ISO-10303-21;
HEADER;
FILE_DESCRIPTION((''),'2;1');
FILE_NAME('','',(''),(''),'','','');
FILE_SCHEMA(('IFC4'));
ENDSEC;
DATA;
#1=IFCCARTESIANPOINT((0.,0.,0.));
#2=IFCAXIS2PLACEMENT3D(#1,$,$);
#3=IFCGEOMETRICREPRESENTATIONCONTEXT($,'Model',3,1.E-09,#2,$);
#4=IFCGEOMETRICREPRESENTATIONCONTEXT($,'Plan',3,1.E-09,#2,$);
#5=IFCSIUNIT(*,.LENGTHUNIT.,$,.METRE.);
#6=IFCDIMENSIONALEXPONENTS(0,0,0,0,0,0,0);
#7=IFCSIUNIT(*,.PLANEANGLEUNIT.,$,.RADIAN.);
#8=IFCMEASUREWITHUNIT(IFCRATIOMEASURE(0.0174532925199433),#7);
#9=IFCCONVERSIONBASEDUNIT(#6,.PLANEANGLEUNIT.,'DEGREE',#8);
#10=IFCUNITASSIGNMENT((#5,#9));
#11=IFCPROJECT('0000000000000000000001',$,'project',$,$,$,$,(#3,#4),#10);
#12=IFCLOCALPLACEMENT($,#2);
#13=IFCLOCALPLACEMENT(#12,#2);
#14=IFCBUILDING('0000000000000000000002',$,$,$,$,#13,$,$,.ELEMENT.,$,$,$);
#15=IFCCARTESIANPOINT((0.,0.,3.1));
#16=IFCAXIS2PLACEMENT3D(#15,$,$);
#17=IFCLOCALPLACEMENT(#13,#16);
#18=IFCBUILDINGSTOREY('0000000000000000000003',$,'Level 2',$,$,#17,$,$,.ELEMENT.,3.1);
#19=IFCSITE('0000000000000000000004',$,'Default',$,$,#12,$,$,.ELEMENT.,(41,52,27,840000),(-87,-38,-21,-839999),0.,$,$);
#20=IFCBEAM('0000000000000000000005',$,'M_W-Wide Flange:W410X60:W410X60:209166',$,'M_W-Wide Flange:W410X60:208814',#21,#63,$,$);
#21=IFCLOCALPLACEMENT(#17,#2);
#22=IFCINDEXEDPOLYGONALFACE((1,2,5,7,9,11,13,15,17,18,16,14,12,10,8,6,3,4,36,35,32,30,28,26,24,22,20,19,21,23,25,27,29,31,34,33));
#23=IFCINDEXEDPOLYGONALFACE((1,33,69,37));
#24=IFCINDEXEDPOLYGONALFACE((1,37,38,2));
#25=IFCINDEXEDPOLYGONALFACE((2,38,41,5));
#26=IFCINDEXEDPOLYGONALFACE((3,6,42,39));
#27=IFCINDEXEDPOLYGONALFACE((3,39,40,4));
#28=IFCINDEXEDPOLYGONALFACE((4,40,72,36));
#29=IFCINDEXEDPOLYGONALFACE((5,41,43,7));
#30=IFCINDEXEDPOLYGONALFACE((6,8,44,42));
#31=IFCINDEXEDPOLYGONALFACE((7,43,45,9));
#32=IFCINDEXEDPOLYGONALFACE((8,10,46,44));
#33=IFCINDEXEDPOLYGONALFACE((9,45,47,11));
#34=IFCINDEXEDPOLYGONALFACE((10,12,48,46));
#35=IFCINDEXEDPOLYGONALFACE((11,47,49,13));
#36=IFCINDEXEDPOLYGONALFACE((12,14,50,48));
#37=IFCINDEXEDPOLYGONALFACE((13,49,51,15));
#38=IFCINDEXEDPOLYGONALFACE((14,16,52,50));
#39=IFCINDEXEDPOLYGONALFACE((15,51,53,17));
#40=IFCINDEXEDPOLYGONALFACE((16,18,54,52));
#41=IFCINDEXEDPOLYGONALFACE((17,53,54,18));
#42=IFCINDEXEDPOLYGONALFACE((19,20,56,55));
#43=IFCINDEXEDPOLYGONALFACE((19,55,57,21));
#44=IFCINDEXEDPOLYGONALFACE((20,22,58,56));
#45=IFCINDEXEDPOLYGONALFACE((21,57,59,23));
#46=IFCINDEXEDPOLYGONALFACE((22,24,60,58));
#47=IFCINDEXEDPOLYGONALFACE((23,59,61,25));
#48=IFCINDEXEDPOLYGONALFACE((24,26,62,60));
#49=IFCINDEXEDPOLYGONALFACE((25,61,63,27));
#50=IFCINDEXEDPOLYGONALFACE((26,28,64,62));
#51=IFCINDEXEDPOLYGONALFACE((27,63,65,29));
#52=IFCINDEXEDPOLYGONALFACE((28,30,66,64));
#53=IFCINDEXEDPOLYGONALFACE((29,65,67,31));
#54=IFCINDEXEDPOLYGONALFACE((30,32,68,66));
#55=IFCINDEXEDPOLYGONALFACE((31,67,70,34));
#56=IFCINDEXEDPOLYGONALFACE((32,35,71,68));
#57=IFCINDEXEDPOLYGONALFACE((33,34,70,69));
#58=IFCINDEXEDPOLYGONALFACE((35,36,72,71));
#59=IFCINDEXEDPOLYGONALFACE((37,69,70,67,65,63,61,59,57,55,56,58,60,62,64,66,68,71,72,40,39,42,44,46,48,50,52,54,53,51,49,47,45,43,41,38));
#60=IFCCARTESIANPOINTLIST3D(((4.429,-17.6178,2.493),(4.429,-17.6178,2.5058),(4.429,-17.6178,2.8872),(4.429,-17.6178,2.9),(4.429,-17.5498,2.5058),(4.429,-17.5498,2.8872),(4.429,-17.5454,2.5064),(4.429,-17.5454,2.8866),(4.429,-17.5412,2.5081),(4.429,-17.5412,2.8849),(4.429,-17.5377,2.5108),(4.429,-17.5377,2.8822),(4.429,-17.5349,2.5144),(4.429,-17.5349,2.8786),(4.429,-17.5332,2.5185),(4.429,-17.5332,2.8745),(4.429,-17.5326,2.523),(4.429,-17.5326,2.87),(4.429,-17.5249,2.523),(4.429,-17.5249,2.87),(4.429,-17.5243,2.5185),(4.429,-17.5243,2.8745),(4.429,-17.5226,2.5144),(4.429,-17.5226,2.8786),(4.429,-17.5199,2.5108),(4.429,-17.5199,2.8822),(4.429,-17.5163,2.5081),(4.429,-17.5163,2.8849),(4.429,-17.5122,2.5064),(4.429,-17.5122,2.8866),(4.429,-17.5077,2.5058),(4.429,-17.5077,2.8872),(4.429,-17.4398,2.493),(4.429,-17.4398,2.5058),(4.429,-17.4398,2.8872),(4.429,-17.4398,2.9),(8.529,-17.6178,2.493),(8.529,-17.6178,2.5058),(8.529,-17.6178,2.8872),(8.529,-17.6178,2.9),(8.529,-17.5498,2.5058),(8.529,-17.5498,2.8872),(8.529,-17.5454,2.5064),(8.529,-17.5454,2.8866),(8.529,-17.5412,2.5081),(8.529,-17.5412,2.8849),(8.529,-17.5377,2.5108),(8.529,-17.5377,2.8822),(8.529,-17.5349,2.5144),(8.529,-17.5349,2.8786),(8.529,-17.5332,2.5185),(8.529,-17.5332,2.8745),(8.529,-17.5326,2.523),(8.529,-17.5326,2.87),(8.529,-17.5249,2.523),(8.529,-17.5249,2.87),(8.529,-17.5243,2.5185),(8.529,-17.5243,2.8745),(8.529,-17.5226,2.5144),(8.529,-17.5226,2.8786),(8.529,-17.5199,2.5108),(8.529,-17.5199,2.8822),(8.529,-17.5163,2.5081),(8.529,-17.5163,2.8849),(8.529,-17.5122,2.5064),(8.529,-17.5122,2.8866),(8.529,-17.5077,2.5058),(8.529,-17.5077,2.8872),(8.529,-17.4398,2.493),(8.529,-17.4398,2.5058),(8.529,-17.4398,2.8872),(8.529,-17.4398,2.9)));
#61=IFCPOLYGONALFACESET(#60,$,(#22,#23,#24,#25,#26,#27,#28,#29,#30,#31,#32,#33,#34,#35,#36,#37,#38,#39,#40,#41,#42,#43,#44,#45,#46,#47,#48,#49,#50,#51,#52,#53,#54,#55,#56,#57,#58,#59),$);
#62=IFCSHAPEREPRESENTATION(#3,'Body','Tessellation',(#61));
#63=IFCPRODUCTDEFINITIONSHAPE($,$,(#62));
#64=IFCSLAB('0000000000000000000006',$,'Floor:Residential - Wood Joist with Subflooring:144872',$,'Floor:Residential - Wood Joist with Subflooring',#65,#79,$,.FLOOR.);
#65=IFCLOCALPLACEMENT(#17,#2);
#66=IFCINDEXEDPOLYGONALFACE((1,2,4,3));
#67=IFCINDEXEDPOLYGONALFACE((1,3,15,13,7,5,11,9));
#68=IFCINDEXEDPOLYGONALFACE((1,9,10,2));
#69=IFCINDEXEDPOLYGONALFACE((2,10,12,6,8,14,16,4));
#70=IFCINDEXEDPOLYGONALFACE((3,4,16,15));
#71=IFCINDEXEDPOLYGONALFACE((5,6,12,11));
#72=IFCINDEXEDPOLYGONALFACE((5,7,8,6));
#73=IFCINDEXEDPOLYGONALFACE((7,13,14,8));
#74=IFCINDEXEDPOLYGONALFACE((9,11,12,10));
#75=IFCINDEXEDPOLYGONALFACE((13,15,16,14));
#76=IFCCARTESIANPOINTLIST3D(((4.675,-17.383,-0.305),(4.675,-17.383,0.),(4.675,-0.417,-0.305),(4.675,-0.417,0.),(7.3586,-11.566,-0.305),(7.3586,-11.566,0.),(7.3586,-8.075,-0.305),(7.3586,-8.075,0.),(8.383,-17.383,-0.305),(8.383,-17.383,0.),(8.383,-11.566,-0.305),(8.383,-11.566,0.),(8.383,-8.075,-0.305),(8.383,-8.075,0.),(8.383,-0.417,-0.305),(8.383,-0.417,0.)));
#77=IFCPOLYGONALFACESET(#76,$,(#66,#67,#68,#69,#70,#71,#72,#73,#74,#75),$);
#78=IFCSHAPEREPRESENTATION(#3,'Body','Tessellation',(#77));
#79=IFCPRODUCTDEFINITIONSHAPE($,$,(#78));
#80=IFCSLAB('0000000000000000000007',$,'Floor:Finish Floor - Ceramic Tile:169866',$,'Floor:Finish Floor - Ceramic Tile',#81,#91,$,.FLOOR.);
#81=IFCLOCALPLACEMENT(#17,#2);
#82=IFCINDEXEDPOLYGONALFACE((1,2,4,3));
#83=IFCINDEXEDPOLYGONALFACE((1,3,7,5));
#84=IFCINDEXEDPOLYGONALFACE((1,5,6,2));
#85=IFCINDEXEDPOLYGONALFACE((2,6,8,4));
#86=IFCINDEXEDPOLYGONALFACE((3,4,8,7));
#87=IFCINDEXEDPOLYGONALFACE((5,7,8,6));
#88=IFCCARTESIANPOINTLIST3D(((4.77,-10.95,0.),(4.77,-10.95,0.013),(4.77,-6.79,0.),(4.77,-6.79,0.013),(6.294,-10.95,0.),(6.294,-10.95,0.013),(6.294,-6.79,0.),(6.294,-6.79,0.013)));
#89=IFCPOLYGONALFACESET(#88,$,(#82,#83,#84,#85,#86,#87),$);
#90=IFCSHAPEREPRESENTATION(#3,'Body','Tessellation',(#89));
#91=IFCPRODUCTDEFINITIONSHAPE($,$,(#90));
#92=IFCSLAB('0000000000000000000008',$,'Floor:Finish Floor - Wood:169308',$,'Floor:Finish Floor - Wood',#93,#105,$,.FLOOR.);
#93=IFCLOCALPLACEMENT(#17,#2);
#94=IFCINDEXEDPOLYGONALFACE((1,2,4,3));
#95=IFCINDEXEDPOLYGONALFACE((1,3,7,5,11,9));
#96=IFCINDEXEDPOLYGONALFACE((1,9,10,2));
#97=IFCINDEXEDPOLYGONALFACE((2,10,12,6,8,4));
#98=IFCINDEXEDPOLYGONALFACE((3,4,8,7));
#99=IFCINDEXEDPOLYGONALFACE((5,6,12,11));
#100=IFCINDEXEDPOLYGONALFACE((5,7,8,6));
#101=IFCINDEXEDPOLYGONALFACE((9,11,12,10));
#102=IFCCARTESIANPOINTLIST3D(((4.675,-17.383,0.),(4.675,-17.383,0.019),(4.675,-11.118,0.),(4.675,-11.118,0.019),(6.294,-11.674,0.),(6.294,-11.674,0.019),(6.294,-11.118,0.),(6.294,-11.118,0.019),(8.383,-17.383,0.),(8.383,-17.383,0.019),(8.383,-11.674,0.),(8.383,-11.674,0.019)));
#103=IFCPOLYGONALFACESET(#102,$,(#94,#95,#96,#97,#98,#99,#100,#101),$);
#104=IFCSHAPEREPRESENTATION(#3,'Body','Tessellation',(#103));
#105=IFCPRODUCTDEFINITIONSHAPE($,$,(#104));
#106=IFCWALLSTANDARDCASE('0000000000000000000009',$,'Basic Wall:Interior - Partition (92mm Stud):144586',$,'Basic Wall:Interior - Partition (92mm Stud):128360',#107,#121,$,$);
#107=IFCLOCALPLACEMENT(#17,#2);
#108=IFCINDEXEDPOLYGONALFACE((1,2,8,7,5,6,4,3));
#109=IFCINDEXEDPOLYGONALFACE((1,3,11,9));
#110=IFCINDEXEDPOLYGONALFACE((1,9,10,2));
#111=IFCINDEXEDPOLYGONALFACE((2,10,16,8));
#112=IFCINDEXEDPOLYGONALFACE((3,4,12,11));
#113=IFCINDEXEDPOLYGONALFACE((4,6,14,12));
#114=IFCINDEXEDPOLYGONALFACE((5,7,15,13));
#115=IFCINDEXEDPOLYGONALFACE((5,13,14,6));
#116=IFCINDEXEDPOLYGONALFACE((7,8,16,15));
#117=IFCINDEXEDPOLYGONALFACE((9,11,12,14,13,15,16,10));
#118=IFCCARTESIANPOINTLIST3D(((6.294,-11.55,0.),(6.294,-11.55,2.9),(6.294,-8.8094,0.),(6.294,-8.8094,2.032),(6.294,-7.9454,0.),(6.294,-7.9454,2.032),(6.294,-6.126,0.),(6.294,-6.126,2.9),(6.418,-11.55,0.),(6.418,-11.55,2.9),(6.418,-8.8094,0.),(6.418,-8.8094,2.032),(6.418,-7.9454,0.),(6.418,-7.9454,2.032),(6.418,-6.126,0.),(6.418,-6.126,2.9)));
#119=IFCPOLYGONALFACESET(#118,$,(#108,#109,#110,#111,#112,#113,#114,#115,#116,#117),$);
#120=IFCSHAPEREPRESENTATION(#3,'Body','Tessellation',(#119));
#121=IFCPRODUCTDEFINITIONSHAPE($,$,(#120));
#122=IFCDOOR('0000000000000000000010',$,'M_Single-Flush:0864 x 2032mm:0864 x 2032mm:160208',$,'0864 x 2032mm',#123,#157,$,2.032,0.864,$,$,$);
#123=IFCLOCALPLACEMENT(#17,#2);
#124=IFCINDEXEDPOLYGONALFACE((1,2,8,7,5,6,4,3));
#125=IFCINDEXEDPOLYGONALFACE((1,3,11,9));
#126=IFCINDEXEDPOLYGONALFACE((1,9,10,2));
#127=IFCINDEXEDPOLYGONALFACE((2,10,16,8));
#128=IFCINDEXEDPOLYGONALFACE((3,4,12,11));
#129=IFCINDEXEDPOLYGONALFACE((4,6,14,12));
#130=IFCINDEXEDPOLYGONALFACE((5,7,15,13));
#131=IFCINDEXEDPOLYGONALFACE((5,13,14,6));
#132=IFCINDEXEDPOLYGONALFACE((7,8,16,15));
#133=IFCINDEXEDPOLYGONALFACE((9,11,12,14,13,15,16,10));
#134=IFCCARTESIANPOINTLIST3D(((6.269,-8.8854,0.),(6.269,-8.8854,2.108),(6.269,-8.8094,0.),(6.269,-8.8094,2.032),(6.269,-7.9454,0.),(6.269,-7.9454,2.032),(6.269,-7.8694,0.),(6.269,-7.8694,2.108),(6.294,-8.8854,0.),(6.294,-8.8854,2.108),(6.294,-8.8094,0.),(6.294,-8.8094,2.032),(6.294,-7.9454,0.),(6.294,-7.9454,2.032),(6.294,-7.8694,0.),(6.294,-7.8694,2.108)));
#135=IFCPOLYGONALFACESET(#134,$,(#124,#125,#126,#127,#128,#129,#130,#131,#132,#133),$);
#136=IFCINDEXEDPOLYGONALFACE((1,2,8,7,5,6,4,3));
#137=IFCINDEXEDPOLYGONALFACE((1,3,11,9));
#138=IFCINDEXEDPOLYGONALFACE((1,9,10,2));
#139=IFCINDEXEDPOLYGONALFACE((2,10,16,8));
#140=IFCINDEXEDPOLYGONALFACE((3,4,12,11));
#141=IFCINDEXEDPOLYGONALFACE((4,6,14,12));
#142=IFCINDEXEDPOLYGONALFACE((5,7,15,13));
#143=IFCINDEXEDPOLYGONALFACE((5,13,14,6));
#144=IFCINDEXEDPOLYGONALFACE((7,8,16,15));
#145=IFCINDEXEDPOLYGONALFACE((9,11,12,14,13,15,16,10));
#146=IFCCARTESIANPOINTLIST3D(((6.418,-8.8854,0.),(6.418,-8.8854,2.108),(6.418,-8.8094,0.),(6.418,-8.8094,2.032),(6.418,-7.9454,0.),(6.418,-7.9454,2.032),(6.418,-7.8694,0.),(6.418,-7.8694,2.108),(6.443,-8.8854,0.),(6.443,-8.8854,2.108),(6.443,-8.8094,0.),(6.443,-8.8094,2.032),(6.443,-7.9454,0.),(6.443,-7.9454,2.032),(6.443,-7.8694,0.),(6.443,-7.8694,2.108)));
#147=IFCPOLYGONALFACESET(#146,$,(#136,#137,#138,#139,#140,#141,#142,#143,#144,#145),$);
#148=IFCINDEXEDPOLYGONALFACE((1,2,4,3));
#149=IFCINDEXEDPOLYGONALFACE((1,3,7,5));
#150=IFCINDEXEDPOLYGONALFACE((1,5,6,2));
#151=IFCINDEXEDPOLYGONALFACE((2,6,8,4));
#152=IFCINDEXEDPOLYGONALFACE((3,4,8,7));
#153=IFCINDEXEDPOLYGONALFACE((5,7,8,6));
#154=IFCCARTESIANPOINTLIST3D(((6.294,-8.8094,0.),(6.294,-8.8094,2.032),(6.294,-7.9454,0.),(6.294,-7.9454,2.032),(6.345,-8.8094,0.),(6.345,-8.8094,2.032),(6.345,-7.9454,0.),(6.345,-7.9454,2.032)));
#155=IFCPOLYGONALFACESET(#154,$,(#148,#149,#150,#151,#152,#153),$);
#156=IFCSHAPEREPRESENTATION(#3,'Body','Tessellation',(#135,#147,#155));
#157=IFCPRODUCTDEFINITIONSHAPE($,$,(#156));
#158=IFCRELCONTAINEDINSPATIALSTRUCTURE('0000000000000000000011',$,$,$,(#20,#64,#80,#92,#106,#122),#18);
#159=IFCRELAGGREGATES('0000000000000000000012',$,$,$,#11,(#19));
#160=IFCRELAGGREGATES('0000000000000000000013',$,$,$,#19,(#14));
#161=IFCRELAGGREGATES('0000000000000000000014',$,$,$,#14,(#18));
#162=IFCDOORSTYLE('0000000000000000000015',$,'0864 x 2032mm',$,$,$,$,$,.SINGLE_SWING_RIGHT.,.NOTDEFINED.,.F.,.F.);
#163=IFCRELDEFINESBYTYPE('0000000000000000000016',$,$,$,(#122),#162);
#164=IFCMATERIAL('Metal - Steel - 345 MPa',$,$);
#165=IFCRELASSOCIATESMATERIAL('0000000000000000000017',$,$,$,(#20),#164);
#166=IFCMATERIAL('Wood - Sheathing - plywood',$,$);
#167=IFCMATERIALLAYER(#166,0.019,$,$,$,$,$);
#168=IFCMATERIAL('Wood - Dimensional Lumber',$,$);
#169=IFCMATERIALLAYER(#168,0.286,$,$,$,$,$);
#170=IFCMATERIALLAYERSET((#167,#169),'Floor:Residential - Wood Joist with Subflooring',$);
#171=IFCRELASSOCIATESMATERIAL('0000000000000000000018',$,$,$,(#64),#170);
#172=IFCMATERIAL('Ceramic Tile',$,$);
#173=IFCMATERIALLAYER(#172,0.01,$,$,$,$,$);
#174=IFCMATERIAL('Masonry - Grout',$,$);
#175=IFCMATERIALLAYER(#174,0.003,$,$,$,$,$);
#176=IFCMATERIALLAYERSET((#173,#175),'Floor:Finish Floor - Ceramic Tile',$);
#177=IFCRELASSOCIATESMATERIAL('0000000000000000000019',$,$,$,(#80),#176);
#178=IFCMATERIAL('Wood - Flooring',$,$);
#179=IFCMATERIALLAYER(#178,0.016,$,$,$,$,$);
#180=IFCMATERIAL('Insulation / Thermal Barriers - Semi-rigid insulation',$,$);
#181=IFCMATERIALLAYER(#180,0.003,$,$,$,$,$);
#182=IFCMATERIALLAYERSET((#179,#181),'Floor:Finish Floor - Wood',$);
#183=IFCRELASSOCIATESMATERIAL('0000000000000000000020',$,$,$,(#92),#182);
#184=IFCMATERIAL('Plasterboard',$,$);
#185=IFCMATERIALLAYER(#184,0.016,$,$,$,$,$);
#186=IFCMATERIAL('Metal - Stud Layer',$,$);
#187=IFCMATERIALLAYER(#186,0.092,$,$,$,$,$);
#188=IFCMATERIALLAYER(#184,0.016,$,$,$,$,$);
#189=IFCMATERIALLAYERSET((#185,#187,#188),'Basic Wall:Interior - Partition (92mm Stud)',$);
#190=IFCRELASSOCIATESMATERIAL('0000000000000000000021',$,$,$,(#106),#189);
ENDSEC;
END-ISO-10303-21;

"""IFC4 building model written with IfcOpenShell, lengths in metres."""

from ifc_helpers import new_model, entity, si_unit, converted_unit, frame, frame_2d, origin, origin_2d_with_axis, place, context, project, spatial, polyline, circle_curve, parameter, trimmed, segment, composite_curve, rectangle, outline, extrude, source, transform, mapped, material, layer, layer_set, layer_usage, type_object, type_shapes, element, fill, save


model = new_model("IFC4")

# Units and contexts
model_context = context("Model", 3, precision=1e-09, world=origin())
plan_context = context("Plan", 3, precision=1e-09, world=origin())
ifc_project = project(units=[si_unit("LENGTHUNIT", "METRE"), converted_unit("PLANEANGLEUNIT", "DEGREE", entity("IfcRatioMeasure", 0.0174532925199433), si_unit("PLANEANGLEUNIT", "RADIAN"), dimensions=[0, 0, 0, 0, 0, 0, 0])], contexts=[model_context, plan_context])

# Site, building, storey
site_placement = place(None, origin())
site = spatial("IfcSite", under=ifc_project, at=site_placement, Name="Default", CompositionType="ELEMENT", RefLatitude=(41, 52, 27, 840000), RefLongitude=(-87, -38, -21, -839999), RefElevation=0.0)
building_placement = place(site_placement, origin())
building = spatial("IfcBuilding", under=site, at=building_placement, CompositionType="ELEMENT")
storey_placement = place(building_placement, frame((0.0, 0.0, 3.1)))
storey = spatial("IfcBuildingStorey", under=building, at=storey_placement, Name="Level 2", CompositionType="ELEMENT", Elevation=3.1)

# Beam
ifc_material_1 = material(Name="Metal - Steel - 345 MPa")
beam_placement = place(storey_placement, frame((4.429, -17.5288, 2.9), z_axis=(0.0, 0.0, 1.0), x_axis=(0.0, -1.0, 0.0)))
element("IfcBeam", 1, at=beam_placement, inside=storey, material=ifc_material_1, Name="M_W-Wide Flange:W410X60:W410X60:209166", ObjectType="M_W-Wide Flange:W410X60:208814", context=model_context, shape_type="SweptSolid", body=[
    extrude(outline(composite_curve([segment(polyline([(-0.089, -0.1907), (-0.089, -0.2035)]), True, "CONTINUOUS"), segment(polyline([(-0.089, -0.2035), (0.089, -0.2035)]), True, "CONTINUOUS"), segment(polyline([(0.089, -0.2035), (0.089, -0.1907)]), True, "CONTINUOUS"), segment(polyline([(0.089, -0.1907), (0.021, -0.1907)]), True, "CONTINUOUS"), segment(trimmed(circle_curve(frame_2d((0.021, -0.1735), x_axis=(0.0, -1.0)), 0.0172), [parameter(270.0)], [parameter(360.0)], True, "PARAMETER"), False, "CONTINUOUS"), segment(polyline([(0.0038, -0.1735), (0.0038, 0.1735)]), True, "CONTINUOUS"), segment(trimmed(circle_curve(frame_2d((0.021, 0.1735), x_axis=(-1.0, 0.0)), 0.0172), [parameter(270.0)], [parameter(360.0)], True, "PARAMETER"), False, "CONTINUOUS"), segment(polyline([(0.021, 0.1907), (0.089, 0.1907)]), True, "CONTINUOUS"), segment(polyline([(0.089, 0.1907), (0.089, 0.2035)]), True, "CONTINUOUS"), segment(polyline([(0.089, 0.2035), (-0.089, 0.2035)]), True, "CONTINUOUS"), segment(polyline([(-0.089, 0.2035), (-0.089, 0.1907)]), True, "CONTINUOUS"), segment(polyline([(-0.089, 0.1907), (-0.0211, 0.1907)]), True, "CONTINUOUS"), segment(trimmed(circle_curve(frame_2d((-0.0211, 0.1735), x_axis=(0.0, 1.0)), 0.0172), [parameter(270.0)], [parameter(0.0)], True, "PARAMETER"), False, "CONTINUOUS"), segment(polyline([(-0.0039, 0.1735), (-0.0039, -0.1735)]), True, "CONTINUOUS"), segment(trimmed(circle_curve(frame_2d((-0.0211, -0.1735), x_axis=(1.0, 0.0)), 0.0172), [parameter(270.0)], [parameter(0.0)], True, "PARAMETER"), False, "CONTINUOUS"), segment(polyline([(-0.0211, -0.1907), (-0.089, -0.1907)]), True, "CONTINUOUS")], self_intersect=False)), frame((0.0, 0.0, -0.2035), z_axis=(0.0, -1.0, 0.0), x_axis=(1.0, 0.0, 0.0)), (0.0, 0.0, -1.0), 4.1),
])

# Slabs
ifc_material_2 = material(Name="Wood - Sheathing - plywood")
ifc_layer_1 = layer(ifc_material_2, 0.019)
ifc_material_3 = material(Name="Wood - Dimensional Lumber")
ifc_layer_2 = layer(ifc_material_3, 0.286)
ifc_layer_set_1 = layer_set([ifc_layer_1, ifc_layer_2], Name="Floor:Residential - Wood Joist with Subflooring")
ifc_layer_usage_1 = layer_usage(ifc_layer_set_1, "AXIS3", "POSITIVE", 0.0)
slab_1_placement = place(storey_placement, frame((4.675, -17.383, -0.305)))
element("IfcSlab", 2, at=slab_1_placement, inside=storey, material=ifc_layer_usage_1, Name="Floor:Residential - Wood Joist with Subflooring:144872", ObjectType="Floor:Residential - Wood Joist with Subflooring", PredefinedType="FLOOR", context=model_context, shape_type="SweptSolid", body=[
    extrude(outline(polyline([(-1.854, 8.483), (-1.854, 0.825), (-0.8296, 0.825), (-0.8296, -2.666), (-1.854, -2.666), (-1.854, -8.483), (1.854, -8.483), (1.854, 8.483), (-1.854, 8.483)])), frame((1.854, 8.483, 0.305), z_axis=(0.0, 0.0, -1.0), x_axis=(-1.0, 0.0, 0.0)), (0.0, 0.0, 1.0), 0.305),
])
ifc_material_4 = material(Name="Ceramic Tile")
ifc_layer_3 = layer(ifc_material_4, 0.01)
ifc_material_5 = material(Name="Masonry - Grout")
ifc_layer_4 = layer(ifc_material_5, 0.003)
ifc_layer_set_2 = layer_set([ifc_layer_3, ifc_layer_4], Name="Floor:Finish Floor - Ceramic Tile")
ifc_layer_usage_2 = layer_usage(ifc_layer_set_2, "AXIS3", "POSITIVE", 0.0)
slab_2_placement = place(storey_placement, frame((4.77, -10.95, 0.0)))
element("IfcSlab", 3, at=slab_2_placement, inside=storey, material=ifc_layer_usage_2, Name="Floor:Finish Floor - Ceramic Tile:169866", ObjectType="Floor:Finish Floor - Ceramic Tile", PredefinedType="FLOOR", context=model_context, shape_type="SweptSolid", body=[
    extrude(rectangle(XDim=4.16, YDim=1.524, at=frame_2d((0.0, 0.0), x_axis=(0.0, -1.0))), frame((0.762, 2.08, 0.013), z_axis=(0.0, 0.0, -1.0), x_axis=(-1.0, 0.0, 0.0)), (0.0, 0.0, 1.0), 0.013),
])
ifc_material_6 = material(Name="Wood - Flooring")
ifc_layer_5 = layer(ifc_material_6, 0.016)
ifc_material_7 = material(Name="Insulation / Thermal Barriers - Semi-rigid insulation")
ifc_layer_6 = layer(ifc_material_7, 0.003)
ifc_layer_set_3 = layer_set([ifc_layer_5, ifc_layer_6], Name="Floor:Finish Floor - Wood")
ifc_layer_usage_3 = layer_usage(ifc_layer_set_3, "AXIS3", "POSITIVE", 0.0)
slab_3_placement = place(storey_placement, frame((4.675, -17.383, 0.0)))
element("IfcSlab", 4, at=slab_3_placement, inside=storey, material=ifc_layer_usage_3, Name="Floor:Finish Floor - Wood:169308", ObjectType="Floor:Finish Floor - Wood", PredefinedType="FLOOR", context=model_context, shape_type="SweptSolid", body=[
    extrude(outline(polyline([(-1.854, 2.5765), (-1.854, -3.1325), (1.854, -3.1325), (1.854, 3.1325), (0.235, 3.1325), (0.235, 2.5765), (-1.854, 2.5765)])), frame((1.854, 3.1325, 0.019), z_axis=(0.0, 0.0, -1.0), x_axis=(-1.0, 0.0, 0.0)), (0.0, 0.0, 1.0), 0.019),
])

# Wall, opening, door
ifc_material_8 = material(Name="Plasterboard")
ifc_layer_7 = layer(ifc_material_8, 0.016)
ifc_material_9 = material(Name="Metal - Stud Layer")
ifc_layer_8 = layer(ifc_material_9, 0.092)
ifc_layer_9 = layer(ifc_material_8, 0.016)
ifc_layer_set_4 = layer_set([ifc_layer_7, ifc_layer_8, ifc_layer_9], Name="Basic Wall:Interior - Partition (92mm Stud)")
ifc_layer_usage_4 = layer_usage(ifc_layer_set_4, "AXIS2", "NEGATIVE", 0.062)
wall_1_placement = place(storey_placement, frame((6.356, -11.55, 0.0), z_axis=(0.0, 0.0, 1.0), x_axis=(0.0, 1.0, 0.0)))
wall_1 = element("IfcWallStandardCase", 5, at=wall_1_placement, inside=storey, material=ifc_layer_usage_4, Name="Basic Wall:Interior - Partition (92mm Stud):144586", ObjectType="Basic Wall:Interior - Partition (92mm Stud):128360", context=model_context, shape_type="SweptSolid", body=[
    extrude(rectangle(XDim=5.424, YDim=0.124, at=frame_2d((2.712, 0.0), x_axis=(-1.0, 0.0))), origin(), (0.0, 0.0, 1.0), 2.9),
])
opening_1_placement = place(wall_1_placement, frame((2.7406, -0.062, 0.0)))
opening_1 = element("IfcOpeningElement", 6, at=opening_1_placement, cuts=wall_1, ObjectType="Opening", context=model_context, shape_type="SweptSolid", body=[
    extrude(rectangle(XDim=0.864, YDim=2.032, at=frame_2d((1.016, 0.432), x_axis=(0.0, 1.0))), frame((0.0, 0.0, 0.0), z_axis=(0.0, 1.0, 0.0), x_axis=(0.0, 0.0, 1.0)), (0.0, 0.0, 1.0), 0.124),
])
door_style = type_object("IfcDoorStyle", Name="0864 x 2032mm", ConstructionType="NOTDEFINED", OperationType="SINGLE_SWING_RIGHT", ParameterTakesPrecedence=False, Sizeable=False)
shared_shape_1 = source(origin(), model_context, "Body", "SweptSolid", [
    extrude(outline(polyline([(-0.508, -1.073), (0.508, -1.073), (0.508, 1.035), (0.432, 1.035), (0.432, -0.997), (-0.432, -0.997), (-0.432, 1.035), (-0.508, 1.035), (-0.508, -1.073)])), frame((0.432, 0.124, 1.035), z_axis=(0.0, 1.0, 0.0), x_axis=(1.0, 0.0, 0.0)), (0.0, 0.0, 1.0), 0.025),
    extrude(outline(polyline([(-1.073, -0.508), (1.035, -0.508), (1.035, -0.432), (-0.997, -0.432), (-0.997, 0.432), (1.035, 0.432), (1.035, 0.508), (-1.073, 0.508), (-1.073, -0.508)])), frame((0.432, -0.025, 1.035), z_axis=(0.0, 1.0, 0.0), x_axis=(0.0, 0.0, -1.0)), (0.0, 0.0, 1.0), 0.025),
    extrude(rectangle(XDim=0.051, YDim=0.864, at=origin_2d_with_axis()), frame((0.432, 0.0985, 0.0), z_axis=(0.0, 0.0, 1.0), x_axis=(0.0, 1.0, 0.0)), (0.0, 0.0, 1.0), 2.032),
])
type_shapes(door_style, [shared_shape_1])
door_placement = place(opening_1_placement, origin())
door = element("IfcDoor", 7, at=door_placement, inside=storey, type_object=door_style, Name="M_Single-Flush:0864 x 2032mm:0864 x 2032mm:160208", ObjectType="0864 x 2032mm", OverallHeight=2.032, OverallWidth=0.864, context=model_context, shape_type="MappedRepresentation", body=[
    mapped(shared_shape_1, transform((0.0, 0.0, 0.0), scale=1.0)),
])
fill(opening_1, door)

save(model, "model.ifc")
